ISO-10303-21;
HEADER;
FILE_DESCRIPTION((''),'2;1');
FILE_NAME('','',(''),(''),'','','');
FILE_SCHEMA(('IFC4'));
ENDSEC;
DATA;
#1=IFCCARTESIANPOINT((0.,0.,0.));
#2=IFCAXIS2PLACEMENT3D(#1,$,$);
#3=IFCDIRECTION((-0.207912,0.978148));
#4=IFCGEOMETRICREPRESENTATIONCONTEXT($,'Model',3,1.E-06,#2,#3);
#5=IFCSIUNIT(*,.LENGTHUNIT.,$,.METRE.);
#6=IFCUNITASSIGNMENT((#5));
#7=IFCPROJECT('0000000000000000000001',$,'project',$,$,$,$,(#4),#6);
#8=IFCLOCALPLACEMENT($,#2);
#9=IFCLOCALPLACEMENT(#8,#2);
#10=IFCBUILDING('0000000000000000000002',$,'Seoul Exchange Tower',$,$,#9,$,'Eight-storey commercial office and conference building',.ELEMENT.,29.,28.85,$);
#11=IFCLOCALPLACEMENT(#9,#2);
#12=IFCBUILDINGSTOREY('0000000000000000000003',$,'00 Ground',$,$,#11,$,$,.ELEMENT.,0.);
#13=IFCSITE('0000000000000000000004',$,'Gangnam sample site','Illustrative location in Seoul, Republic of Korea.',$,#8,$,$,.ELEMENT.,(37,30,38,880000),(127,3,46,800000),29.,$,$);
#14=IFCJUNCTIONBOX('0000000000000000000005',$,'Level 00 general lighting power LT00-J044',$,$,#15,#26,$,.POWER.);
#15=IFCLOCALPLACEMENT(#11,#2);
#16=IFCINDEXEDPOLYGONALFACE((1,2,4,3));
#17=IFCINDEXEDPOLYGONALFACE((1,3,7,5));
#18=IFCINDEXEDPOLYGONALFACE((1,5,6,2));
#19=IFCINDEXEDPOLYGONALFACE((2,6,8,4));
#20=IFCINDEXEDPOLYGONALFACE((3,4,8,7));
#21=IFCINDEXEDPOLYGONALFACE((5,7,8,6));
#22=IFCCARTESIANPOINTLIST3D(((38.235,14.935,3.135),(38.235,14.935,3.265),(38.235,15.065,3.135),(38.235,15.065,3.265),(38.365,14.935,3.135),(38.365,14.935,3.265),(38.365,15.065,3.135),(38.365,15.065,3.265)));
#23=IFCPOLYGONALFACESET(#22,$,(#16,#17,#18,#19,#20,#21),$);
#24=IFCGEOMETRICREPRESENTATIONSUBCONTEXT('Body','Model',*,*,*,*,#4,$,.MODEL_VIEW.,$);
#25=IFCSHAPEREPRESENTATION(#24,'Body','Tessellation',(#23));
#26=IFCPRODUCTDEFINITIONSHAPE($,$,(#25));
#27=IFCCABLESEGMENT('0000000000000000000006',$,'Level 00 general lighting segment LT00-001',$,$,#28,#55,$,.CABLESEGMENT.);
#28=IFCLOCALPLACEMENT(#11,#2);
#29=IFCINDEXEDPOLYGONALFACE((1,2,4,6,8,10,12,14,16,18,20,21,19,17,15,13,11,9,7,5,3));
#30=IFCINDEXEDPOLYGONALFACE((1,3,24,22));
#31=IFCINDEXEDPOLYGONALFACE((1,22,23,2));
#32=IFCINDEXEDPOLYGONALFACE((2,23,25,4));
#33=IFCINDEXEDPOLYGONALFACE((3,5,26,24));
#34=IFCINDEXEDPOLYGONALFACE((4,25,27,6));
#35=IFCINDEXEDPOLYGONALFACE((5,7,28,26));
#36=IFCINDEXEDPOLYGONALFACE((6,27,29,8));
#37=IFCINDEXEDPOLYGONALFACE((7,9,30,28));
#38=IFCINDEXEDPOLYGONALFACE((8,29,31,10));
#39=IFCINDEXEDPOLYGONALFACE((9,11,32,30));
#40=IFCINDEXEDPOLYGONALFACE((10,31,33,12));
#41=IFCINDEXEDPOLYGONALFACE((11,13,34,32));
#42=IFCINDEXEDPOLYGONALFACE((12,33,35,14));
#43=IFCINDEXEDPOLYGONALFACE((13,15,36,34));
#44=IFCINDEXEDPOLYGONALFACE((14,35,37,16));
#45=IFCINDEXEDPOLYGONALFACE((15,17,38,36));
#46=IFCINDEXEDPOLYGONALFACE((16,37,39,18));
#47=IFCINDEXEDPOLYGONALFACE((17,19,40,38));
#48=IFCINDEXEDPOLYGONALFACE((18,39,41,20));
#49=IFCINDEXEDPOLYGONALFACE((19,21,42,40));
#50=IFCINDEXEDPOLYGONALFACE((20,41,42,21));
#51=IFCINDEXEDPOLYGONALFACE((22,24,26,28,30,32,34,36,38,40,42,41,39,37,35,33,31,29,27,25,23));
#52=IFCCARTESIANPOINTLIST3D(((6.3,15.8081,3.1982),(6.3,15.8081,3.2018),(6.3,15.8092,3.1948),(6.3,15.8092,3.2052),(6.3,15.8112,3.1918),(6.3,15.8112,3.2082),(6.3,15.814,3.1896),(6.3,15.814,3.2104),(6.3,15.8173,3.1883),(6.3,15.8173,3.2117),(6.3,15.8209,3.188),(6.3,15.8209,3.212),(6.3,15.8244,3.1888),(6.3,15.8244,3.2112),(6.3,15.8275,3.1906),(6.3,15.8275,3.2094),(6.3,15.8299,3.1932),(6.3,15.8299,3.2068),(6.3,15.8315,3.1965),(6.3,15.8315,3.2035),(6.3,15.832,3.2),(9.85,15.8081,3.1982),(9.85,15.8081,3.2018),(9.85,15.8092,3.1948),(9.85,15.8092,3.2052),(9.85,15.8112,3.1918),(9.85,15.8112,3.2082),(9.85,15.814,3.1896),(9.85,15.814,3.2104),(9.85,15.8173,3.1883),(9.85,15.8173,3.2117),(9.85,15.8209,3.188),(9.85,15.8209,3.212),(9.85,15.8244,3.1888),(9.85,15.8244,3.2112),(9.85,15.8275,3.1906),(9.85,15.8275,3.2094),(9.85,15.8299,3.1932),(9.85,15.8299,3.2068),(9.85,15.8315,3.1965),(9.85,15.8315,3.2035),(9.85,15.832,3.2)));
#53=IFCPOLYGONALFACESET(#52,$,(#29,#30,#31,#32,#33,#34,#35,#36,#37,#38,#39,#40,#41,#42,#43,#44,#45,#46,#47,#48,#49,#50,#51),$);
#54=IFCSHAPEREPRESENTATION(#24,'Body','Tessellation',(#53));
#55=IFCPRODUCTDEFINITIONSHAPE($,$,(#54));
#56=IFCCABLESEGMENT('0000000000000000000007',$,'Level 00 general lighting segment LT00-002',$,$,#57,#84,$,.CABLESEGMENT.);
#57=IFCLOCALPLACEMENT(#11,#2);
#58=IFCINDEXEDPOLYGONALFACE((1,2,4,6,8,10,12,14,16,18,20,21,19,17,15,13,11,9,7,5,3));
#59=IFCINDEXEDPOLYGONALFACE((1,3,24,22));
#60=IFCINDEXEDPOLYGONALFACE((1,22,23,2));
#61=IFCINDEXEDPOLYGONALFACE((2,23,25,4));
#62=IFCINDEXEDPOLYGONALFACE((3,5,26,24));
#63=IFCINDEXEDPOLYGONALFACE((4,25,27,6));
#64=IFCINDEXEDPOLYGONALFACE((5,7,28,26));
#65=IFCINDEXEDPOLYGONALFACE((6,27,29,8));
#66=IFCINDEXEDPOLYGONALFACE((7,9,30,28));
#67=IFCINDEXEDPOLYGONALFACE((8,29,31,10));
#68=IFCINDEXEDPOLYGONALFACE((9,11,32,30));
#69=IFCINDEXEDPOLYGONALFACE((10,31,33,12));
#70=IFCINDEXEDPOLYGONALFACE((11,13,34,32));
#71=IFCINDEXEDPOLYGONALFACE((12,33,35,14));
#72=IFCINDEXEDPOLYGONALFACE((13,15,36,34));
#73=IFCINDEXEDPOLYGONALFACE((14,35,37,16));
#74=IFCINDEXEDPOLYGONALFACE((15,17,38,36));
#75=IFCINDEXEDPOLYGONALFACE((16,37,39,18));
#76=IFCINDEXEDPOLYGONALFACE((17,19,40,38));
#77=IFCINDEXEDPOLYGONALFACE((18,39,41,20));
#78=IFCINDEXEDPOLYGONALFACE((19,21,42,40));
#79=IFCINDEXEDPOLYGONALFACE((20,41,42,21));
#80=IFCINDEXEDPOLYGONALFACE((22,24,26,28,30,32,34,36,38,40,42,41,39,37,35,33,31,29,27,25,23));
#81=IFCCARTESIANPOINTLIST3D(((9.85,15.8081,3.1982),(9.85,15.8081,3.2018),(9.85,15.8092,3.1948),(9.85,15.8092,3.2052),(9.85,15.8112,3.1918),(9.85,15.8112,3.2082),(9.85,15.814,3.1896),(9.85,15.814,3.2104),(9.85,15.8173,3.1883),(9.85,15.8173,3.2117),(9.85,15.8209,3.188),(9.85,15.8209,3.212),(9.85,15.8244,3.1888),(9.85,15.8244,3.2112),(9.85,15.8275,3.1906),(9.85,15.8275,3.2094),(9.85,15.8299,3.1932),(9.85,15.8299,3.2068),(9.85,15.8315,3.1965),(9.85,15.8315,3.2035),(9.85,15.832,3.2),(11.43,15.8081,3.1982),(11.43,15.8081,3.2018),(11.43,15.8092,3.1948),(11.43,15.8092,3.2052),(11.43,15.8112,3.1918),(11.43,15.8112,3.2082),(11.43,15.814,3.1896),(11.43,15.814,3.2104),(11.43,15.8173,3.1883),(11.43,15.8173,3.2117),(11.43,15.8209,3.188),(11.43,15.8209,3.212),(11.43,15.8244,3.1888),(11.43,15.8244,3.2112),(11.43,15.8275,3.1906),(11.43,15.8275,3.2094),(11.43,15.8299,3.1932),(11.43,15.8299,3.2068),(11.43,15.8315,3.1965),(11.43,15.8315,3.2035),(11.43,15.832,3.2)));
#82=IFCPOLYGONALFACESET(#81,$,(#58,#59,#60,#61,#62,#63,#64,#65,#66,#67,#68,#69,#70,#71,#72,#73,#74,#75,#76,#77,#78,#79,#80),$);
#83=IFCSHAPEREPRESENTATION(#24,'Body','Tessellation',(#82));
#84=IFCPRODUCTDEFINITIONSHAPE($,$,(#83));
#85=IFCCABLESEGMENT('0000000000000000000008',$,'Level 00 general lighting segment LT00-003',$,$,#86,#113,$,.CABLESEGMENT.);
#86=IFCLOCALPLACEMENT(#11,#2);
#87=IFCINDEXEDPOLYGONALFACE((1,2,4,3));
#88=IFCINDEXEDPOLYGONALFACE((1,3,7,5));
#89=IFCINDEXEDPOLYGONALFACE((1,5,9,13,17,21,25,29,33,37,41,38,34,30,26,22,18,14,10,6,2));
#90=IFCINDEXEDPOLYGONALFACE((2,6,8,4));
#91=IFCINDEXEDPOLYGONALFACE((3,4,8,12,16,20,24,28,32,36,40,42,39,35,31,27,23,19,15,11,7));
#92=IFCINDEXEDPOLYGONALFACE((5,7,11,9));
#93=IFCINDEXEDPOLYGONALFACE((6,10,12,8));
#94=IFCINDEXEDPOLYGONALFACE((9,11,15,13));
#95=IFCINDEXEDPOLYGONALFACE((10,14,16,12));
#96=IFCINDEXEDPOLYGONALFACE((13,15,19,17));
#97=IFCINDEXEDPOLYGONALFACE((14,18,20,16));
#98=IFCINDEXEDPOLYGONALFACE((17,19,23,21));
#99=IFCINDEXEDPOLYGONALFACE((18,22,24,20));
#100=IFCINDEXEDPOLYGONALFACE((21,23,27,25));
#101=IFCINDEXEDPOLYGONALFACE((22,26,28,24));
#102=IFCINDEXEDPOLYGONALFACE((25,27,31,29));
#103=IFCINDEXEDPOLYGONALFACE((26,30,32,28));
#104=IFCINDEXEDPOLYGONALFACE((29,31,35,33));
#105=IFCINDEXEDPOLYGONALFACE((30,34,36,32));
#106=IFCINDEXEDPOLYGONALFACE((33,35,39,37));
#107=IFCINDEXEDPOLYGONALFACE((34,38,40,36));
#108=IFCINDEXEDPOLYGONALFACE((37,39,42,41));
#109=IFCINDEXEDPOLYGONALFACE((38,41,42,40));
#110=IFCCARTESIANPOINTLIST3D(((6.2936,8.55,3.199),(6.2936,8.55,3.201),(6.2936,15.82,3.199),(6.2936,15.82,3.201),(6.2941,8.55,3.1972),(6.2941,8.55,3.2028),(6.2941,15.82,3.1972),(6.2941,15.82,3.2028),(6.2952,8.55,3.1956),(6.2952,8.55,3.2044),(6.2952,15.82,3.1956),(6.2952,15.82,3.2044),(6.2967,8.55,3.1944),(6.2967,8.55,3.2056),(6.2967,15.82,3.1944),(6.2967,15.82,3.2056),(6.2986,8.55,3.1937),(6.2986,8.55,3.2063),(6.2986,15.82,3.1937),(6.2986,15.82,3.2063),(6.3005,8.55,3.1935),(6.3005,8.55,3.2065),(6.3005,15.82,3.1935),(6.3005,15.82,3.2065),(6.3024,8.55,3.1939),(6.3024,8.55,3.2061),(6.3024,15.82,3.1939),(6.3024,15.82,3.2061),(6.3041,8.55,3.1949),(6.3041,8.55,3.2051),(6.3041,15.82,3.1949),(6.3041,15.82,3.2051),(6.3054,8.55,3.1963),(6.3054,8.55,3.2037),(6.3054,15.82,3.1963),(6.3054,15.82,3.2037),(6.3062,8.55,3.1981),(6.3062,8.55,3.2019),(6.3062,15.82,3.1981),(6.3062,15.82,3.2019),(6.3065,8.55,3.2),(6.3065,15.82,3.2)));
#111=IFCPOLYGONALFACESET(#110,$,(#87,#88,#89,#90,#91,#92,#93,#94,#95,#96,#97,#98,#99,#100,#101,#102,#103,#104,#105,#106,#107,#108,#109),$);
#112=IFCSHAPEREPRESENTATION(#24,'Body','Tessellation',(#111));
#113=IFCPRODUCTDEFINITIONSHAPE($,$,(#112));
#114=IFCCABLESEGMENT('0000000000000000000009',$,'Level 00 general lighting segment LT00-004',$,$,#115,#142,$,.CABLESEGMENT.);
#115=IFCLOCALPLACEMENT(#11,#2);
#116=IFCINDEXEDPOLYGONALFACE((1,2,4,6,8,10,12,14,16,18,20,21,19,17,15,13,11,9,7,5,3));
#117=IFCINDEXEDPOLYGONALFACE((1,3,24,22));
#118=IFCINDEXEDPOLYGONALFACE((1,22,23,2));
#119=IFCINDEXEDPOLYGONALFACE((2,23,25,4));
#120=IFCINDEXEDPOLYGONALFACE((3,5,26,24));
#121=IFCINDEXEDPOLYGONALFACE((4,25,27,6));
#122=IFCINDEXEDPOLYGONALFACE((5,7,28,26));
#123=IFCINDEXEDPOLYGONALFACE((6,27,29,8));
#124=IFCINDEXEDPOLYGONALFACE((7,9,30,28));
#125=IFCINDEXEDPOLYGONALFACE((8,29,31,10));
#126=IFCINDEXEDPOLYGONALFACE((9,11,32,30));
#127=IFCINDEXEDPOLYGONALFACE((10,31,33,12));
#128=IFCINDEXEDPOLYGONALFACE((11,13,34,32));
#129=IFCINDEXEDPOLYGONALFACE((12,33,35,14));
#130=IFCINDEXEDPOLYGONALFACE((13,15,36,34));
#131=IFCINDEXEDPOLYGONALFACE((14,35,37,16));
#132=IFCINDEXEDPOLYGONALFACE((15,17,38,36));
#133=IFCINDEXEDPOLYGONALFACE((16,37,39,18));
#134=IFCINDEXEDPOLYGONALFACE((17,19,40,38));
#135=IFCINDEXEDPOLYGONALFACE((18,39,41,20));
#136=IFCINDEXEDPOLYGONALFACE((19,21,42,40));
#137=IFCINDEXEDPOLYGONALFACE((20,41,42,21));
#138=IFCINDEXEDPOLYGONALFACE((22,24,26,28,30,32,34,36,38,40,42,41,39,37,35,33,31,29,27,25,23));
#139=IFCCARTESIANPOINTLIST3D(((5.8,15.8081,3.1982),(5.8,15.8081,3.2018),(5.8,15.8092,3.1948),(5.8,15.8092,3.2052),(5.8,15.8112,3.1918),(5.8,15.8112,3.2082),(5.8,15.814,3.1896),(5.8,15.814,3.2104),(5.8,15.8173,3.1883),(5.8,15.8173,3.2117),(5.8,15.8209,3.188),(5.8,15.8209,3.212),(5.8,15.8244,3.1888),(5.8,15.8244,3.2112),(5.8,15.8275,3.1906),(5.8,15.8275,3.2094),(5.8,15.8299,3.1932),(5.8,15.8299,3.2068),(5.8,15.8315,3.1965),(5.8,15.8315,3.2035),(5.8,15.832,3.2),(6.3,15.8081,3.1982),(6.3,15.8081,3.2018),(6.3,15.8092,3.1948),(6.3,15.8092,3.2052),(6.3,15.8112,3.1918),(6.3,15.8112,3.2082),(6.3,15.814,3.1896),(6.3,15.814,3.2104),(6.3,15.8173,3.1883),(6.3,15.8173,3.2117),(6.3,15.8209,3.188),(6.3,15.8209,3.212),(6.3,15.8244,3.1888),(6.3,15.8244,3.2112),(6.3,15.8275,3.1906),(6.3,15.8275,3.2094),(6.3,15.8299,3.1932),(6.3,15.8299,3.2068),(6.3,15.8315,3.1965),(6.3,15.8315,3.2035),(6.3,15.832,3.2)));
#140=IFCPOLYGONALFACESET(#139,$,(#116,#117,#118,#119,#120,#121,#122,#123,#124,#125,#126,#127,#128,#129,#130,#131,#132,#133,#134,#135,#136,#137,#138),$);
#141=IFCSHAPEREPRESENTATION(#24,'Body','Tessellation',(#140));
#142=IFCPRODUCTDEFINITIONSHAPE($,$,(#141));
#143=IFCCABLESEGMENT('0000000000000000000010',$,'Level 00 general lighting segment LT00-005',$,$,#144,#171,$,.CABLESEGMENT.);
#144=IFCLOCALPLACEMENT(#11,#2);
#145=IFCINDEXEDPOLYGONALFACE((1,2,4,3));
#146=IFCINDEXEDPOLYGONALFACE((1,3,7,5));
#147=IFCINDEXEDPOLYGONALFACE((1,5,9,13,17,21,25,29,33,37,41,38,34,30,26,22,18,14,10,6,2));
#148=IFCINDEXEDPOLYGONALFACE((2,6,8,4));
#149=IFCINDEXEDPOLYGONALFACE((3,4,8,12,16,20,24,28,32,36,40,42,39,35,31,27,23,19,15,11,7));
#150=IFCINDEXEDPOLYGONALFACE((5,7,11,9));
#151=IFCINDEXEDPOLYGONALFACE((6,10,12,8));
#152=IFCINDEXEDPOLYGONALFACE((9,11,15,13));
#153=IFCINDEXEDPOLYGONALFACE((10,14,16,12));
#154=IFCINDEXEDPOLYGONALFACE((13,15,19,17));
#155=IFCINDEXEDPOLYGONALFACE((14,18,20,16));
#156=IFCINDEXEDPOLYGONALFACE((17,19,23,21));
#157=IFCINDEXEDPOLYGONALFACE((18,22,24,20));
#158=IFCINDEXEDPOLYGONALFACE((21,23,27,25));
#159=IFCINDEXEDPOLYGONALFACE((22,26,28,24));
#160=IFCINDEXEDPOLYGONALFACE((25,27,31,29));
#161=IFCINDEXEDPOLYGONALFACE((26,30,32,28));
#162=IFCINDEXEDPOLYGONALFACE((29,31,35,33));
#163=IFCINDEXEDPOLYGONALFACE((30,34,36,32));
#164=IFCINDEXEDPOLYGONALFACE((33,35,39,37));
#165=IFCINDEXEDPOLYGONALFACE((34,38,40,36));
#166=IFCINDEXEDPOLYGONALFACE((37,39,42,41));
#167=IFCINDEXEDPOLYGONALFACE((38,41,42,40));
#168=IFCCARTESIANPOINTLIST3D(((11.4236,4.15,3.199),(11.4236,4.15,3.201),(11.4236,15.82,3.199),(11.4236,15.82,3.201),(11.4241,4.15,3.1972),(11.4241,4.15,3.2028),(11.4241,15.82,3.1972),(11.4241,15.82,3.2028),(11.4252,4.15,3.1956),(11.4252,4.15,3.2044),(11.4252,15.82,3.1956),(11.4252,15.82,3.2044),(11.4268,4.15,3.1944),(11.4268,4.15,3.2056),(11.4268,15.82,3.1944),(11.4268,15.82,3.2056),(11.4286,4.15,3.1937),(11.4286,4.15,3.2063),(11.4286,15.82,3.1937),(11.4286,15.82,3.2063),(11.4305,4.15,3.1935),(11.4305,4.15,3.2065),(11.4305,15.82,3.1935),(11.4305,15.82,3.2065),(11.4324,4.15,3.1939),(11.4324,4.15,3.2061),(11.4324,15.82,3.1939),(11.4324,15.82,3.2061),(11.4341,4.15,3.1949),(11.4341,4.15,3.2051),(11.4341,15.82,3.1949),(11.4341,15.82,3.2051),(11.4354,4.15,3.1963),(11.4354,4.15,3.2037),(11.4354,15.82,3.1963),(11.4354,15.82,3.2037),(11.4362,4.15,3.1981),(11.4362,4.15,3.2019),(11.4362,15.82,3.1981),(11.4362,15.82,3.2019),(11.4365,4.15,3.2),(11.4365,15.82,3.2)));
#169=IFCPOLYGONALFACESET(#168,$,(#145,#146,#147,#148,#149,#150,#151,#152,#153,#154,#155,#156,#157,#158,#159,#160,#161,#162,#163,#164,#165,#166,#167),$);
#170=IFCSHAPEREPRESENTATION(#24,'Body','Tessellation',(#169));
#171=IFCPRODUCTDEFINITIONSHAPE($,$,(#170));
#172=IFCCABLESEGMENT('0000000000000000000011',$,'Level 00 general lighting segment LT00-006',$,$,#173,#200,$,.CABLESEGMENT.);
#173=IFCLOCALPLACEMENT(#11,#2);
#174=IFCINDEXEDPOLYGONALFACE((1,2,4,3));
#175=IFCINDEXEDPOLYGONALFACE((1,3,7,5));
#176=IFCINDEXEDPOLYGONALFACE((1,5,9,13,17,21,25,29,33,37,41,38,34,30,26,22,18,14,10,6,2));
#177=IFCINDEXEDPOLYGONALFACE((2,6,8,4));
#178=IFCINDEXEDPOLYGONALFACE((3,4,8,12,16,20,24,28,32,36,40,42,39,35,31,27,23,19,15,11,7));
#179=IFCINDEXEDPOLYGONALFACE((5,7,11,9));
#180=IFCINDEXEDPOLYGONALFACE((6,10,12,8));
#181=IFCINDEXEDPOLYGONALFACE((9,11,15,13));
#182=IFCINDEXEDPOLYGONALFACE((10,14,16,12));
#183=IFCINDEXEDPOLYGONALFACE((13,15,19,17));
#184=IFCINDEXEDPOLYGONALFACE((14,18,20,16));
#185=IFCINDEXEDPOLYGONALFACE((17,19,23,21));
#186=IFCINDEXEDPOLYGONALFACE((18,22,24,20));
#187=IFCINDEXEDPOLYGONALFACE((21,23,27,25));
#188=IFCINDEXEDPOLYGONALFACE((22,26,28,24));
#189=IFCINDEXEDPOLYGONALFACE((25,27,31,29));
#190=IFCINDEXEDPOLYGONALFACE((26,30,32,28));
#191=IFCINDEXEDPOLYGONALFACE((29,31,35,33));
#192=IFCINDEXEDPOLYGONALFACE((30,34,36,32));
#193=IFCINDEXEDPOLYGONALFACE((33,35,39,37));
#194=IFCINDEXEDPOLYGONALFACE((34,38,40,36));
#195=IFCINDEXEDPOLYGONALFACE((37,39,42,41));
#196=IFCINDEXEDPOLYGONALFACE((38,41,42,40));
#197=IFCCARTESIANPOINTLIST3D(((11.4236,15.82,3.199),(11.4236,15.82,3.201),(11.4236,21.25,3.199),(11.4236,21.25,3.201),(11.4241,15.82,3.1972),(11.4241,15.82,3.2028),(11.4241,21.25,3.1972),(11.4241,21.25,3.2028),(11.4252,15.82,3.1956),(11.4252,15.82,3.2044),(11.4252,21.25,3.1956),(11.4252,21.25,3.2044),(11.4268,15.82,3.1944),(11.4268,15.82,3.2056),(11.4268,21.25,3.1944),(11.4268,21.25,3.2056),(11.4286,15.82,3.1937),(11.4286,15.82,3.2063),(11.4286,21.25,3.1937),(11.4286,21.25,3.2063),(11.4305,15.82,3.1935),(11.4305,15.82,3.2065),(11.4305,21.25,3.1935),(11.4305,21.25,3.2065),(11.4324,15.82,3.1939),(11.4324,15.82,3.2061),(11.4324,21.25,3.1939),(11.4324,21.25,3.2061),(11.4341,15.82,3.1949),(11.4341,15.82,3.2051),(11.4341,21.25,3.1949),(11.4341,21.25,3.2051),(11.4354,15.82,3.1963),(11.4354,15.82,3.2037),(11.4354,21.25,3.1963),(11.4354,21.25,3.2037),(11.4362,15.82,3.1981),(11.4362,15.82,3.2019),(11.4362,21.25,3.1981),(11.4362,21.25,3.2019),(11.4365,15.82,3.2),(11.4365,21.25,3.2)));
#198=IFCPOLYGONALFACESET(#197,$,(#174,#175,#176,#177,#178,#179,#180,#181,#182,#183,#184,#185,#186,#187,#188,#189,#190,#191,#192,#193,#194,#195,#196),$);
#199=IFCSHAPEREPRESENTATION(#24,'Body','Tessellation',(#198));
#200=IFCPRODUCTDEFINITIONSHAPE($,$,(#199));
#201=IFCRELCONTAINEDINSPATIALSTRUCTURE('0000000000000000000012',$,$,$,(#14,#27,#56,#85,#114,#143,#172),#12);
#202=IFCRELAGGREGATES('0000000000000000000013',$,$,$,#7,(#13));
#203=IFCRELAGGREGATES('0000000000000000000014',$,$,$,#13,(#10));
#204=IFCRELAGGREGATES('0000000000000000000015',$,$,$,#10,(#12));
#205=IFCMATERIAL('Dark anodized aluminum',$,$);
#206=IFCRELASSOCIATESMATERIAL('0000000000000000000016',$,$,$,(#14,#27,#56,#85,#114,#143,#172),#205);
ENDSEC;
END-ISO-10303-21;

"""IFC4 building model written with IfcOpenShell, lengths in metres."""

from ifc_helpers import new_model, si_unit, direction, frame, frame_2d, origin, place, context, subcontext, project, spatial, rectangle, circle, extrude, material, element, save


model = new_model("IFC4")

# Units and contexts
model_context = context("Model", 3, precision=1e-06, world=origin(), true_north=direction((-0.207912, 0.978148)))
body_context = subcontext(model_context, "Body", "Model", "MODEL_VIEW")
ifc_project = project(units=[si_unit("LENGTHUNIT", "METRE")], contexts=[model_context])

# Site, building, storey
site_placement = place(None, origin())
site = spatial("IfcSite", under=ifc_project, at=site_placement, Name="Gangnam sample site", Description="Illustrative location in Seoul, Republic of Korea.", CompositionType="ELEMENT", RefLatitude=(37, 30, 38, 880000), RefLongitude=(127, 3, 46, 800000), RefElevation=29.0)
building_placement = place(site_placement, origin())
building = spatial("IfcBuilding", under=site, at=building_placement, Name="Seoul Exchange Tower", LongName="Eight-storey commercial office and conference building", CompositionType="ELEMENT", ElevationOfRefHeight=29.0, ElevationOfTerrain=28.85)
storey_placement = place(building_placement, origin())
storey = spatial("IfcBuildingStorey", under=building, at=storey_placement, Name="00 Ground", CompositionType="ELEMENT", Elevation=0.0)

# Junction box
ifc_material = material(Name="Dark anodized aluminum")
placement = place(storey_placement, origin())
element("IfcJunctionBox", 1, at=placement, inside=storey, material=ifc_material, Name="Level 00 general lighting power LT00-J044", PredefinedType="POWER", context=body_context, shape_type="SweptSolid", body=[
    extrude(rectangle(XDim=0.13, YDim=0.13, at=frame_2d((0.065, 0.065))), frame((38.235, 14.935, 3.135)), (0.0, 0.0, 1.0), 0.13),
])

# Cable segments
element("IfcCableSegment", 2, at=placement, inside=storey, material=ifc_material, Name="Level 00 general lighting segment LT00-001", PredefinedType="CABLESEGMENT", context=body_context, shape_type="SweptSolid", body=[
    extrude(circle(Radius=0.012), frame((9.85, 15.82, 3.2), z_axis=(-1.0, 0.0, 0.0), x_axis=(0.0, 1.0, 0.0)), (0.0, 0.0, 1.0), 3.55),
])
element("IfcCableSegment", 3, at=placement, inside=storey, material=ifc_material, Name="Level 00 general lighting segment LT00-002", PredefinedType="CABLESEGMENT", context=body_context, shape_type="SweptSolid", body=[
    extrude(circle(Radius=0.012), frame((9.85, 15.82, 3.2), z_axis=(1.0, 0.0, 0.0), x_axis=(0.0, 1.0, 0.0)), (0.0, 0.0, 1.0), 1.58),
])
element("IfcCableSegment", 4, at=placement, inside=storey, material=ifc_material, Name="Level 00 general lighting segment LT00-003", PredefinedType="CABLESEGMENT", context=body_context, shape_type="SweptSolid", body=[
    extrude(circle(Radius=0.0065), frame((6.3, 15.82, 3.2), z_axis=(0.0, -1.0, 0.0), x_axis=(1.0, 0.0, 0.0)), (0.0, 0.0, 1.0), 7.27),
])
element("IfcCableSegment", 5, at=placement, inside=storey, material=ifc_material, Name="Level 00 general lighting segment LT00-004", PredefinedType="CABLESEGMENT", context=body_context, shape_type="SweptSolid", body=[
    extrude(circle(Radius=0.012), frame((6.3, 15.82, 3.2), z_axis=(-1.0, 0.0, 0.0), x_axis=(0.0, 1.0, 0.0)), (0.0, 0.0, 1.0), 0.5),
])
element("IfcCableSegment", 6, at=placement, inside=storey, material=ifc_material, Name="Level 00 general lighting segment LT00-005", PredefinedType="CABLESEGMENT", context=body_context, shape_type="SweptSolid", body=[
    extrude(circle(Radius=0.0065), frame((11.43, 15.82, 3.2), z_axis=(0.0, -1.0, 0.0), x_axis=(1.0, 0.0, 0.0)), (0.0, 0.0, 1.0), 11.67),
])
element("IfcCableSegment", 7, at=placement, inside=storey, material=ifc_material, Name="Level 00 general lighting segment LT00-006", PredefinedType="CABLESEGMENT", context=body_context, shape_type="SweptSolid", body=[
    extrude(circle(Radius=0.0065), frame((11.43, 15.82, 3.2), z_axis=(0.0, 1.0, 0.0), x_axis=(1.0, 0.0, 0.0)), (0.0, 0.0, 1.0), 5.43),
])

save(model, "model.ifc")
